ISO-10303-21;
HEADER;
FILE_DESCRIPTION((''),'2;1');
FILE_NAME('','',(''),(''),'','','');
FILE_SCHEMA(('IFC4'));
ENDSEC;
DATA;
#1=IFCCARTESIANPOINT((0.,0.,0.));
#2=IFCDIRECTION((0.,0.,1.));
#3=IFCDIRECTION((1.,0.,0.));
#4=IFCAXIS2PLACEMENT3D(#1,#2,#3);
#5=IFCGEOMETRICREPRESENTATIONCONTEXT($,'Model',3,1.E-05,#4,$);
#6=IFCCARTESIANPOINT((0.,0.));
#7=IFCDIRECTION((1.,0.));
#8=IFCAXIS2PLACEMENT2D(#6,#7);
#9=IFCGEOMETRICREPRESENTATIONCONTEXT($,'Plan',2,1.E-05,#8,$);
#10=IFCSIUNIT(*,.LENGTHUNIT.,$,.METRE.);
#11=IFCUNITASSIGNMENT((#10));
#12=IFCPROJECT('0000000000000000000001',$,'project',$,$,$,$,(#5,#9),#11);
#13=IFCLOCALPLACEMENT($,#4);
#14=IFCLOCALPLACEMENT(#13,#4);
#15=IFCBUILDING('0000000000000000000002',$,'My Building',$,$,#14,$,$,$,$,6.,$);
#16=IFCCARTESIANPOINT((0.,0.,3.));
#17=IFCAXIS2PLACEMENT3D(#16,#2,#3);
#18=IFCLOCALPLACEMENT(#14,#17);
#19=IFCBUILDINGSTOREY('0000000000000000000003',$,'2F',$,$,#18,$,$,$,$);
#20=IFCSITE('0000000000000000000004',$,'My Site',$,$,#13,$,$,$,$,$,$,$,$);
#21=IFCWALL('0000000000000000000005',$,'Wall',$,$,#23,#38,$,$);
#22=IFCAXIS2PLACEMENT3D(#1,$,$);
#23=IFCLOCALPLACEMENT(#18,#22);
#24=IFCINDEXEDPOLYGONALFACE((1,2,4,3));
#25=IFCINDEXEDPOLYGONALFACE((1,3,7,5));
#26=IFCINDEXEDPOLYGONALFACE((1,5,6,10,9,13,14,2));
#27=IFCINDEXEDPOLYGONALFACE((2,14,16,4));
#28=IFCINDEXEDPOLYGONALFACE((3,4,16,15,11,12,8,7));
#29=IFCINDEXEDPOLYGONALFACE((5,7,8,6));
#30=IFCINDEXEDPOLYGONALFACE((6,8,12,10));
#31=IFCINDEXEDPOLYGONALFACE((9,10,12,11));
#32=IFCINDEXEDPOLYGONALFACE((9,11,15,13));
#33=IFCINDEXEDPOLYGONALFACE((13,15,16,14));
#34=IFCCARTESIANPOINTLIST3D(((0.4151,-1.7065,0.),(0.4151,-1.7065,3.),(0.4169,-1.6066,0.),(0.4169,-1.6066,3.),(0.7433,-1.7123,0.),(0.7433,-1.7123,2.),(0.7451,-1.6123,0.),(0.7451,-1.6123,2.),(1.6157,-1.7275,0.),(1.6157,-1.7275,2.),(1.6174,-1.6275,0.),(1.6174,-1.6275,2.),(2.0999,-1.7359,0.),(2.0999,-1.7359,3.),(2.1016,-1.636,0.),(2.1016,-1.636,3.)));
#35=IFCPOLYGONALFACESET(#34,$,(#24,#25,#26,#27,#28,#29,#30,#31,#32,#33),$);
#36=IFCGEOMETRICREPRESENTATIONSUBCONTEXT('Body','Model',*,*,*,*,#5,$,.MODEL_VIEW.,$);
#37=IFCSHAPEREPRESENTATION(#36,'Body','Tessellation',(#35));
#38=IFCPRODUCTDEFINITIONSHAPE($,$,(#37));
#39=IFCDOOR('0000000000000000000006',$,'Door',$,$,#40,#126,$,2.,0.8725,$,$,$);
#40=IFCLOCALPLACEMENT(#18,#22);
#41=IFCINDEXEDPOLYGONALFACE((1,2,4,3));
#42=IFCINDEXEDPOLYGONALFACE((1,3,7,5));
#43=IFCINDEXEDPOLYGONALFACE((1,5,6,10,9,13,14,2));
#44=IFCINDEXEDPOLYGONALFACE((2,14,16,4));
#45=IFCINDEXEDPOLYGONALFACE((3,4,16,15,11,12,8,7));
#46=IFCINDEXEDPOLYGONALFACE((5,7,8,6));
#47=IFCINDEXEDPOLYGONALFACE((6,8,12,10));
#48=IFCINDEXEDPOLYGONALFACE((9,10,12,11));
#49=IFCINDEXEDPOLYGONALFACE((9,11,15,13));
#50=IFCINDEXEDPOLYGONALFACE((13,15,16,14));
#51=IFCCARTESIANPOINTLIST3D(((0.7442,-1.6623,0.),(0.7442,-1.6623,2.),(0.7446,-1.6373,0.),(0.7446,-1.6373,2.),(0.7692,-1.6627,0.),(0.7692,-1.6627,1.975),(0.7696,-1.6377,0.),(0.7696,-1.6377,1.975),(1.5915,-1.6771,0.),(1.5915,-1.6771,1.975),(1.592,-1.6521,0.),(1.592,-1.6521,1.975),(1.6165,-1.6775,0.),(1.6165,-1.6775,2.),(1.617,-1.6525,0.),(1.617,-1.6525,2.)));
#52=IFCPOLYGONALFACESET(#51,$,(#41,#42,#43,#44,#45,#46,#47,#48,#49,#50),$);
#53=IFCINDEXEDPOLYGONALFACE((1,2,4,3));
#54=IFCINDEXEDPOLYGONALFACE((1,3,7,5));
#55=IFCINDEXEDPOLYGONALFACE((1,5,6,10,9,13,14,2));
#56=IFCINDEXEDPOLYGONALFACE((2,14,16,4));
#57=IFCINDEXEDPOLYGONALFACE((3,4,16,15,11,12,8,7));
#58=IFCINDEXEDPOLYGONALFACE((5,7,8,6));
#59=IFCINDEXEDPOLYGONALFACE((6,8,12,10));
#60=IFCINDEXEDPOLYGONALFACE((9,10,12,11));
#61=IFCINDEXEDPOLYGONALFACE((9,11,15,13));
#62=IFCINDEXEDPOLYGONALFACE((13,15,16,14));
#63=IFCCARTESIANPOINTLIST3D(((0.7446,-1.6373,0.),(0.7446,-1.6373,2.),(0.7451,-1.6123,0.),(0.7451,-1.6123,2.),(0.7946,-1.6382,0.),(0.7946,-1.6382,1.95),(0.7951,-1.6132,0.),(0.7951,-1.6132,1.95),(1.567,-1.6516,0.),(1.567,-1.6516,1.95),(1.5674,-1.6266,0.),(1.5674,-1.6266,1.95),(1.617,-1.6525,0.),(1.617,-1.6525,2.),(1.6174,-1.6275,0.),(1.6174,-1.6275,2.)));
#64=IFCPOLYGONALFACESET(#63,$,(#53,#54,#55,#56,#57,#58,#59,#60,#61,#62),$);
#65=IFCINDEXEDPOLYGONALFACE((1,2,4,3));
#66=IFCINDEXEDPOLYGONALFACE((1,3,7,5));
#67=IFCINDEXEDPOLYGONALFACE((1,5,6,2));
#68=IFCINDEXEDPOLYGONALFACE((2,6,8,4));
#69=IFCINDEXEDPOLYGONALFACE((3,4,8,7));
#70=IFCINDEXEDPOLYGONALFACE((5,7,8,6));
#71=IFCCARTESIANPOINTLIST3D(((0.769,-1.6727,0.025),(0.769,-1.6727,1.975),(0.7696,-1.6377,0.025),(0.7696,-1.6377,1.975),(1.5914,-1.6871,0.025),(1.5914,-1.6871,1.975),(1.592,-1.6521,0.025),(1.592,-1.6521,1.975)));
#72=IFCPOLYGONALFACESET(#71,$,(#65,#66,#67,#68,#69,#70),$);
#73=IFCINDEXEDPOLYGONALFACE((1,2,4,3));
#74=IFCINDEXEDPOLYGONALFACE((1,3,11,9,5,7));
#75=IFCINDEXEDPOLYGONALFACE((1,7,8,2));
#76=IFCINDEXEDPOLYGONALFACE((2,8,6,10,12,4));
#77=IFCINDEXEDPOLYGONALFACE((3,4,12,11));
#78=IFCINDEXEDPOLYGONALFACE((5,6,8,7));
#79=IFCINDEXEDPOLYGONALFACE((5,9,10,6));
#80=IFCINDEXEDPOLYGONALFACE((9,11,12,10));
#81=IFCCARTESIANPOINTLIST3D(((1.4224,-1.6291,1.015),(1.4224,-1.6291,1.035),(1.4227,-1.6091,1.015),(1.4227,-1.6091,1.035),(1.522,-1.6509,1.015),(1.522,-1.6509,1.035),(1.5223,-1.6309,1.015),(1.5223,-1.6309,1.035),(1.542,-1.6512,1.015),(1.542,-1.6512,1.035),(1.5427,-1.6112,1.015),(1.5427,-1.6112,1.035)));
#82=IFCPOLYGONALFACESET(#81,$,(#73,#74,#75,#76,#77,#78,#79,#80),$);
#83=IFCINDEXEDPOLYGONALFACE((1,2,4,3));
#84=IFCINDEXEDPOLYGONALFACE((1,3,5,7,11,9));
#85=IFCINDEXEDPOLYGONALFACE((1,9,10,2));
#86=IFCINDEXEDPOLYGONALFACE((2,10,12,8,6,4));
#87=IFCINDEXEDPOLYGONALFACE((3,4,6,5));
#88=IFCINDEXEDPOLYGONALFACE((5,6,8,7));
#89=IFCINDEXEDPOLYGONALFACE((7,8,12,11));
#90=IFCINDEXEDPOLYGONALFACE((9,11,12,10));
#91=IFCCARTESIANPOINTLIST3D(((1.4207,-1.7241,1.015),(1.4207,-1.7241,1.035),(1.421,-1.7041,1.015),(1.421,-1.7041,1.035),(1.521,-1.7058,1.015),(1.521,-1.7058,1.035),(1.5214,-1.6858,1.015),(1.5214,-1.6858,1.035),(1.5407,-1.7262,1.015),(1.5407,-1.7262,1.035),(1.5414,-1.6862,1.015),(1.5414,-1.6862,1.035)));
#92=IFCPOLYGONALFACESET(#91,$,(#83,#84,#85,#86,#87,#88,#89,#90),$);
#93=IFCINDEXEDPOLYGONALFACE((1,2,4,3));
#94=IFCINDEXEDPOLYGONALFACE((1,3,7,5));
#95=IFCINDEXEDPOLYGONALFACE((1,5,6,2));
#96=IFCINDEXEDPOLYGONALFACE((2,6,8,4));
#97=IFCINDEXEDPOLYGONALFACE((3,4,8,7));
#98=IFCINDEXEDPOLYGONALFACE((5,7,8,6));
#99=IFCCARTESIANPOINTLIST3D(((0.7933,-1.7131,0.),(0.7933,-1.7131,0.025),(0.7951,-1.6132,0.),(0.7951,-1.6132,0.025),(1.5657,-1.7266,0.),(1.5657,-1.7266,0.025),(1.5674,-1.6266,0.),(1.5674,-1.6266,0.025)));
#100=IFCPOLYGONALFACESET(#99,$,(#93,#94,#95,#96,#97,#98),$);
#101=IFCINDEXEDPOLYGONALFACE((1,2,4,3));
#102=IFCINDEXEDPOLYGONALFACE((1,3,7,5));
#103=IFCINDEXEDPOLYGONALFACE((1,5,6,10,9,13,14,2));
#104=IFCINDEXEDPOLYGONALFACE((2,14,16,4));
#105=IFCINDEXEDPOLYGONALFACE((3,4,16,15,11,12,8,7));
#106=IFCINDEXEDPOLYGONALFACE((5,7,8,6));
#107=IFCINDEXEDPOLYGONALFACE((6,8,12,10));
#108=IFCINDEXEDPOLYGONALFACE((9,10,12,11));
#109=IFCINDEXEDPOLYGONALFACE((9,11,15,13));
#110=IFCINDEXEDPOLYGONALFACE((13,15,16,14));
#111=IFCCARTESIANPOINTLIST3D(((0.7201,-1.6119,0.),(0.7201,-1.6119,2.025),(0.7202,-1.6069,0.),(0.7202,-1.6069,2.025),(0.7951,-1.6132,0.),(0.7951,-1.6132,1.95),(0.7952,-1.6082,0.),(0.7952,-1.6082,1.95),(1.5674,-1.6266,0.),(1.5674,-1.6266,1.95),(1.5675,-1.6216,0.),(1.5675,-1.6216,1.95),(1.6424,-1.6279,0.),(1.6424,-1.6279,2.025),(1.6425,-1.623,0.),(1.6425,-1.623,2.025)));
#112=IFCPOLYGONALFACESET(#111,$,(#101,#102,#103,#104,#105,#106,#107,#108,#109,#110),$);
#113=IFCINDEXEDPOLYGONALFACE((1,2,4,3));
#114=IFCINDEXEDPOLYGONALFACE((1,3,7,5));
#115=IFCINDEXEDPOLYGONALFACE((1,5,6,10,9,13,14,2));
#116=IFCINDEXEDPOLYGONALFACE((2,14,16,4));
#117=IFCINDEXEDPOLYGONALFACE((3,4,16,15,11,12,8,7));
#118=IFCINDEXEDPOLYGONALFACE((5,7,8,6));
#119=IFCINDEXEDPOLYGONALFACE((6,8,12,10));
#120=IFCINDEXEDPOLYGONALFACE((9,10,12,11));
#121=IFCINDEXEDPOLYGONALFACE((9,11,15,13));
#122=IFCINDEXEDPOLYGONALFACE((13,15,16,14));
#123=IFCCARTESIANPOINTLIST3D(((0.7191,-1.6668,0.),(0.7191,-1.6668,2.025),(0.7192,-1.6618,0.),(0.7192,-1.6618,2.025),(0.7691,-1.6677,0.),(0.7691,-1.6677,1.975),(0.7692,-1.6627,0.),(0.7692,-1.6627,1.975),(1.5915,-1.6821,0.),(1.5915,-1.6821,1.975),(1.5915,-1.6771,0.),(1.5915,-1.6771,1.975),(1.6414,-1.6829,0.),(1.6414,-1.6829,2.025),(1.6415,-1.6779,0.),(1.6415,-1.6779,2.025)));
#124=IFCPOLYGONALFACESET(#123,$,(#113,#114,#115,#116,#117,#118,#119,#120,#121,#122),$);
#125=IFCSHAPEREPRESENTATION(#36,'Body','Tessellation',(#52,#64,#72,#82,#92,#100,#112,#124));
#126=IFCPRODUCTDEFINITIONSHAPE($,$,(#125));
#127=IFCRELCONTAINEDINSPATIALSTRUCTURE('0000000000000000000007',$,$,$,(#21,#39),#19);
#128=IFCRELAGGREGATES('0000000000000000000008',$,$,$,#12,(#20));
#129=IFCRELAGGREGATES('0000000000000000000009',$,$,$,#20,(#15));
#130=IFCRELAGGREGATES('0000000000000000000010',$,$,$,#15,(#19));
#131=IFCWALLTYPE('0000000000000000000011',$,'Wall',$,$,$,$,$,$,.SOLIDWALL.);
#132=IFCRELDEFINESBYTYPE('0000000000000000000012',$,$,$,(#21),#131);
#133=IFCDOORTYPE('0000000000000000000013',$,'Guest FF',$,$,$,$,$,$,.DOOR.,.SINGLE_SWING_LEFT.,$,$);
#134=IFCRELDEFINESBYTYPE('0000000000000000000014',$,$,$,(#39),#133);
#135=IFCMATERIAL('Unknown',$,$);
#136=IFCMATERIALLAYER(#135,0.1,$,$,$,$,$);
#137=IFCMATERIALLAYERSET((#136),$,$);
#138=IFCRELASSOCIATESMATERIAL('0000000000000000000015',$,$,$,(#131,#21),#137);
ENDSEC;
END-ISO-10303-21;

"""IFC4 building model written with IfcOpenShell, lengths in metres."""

from ifc_helpers import new_model, entity, si_unit, frame, origin_with_axes, origin_2d_with_axis, place, context, subcontext, project, spatial, line, indexed_curve, outline, extrude, shape, source, transform, mapped, material, layer, layer_set, layer_usage, type_object, type_shapes, element, fill, save


model = new_model("IFC4")

# Units and contexts
model_context = context("Model", 3, precision=1e-05, world=origin_with_axes())
plan_context = context("Plan", 2, precision=1e-05, world=origin_2d_with_axis())
body_context_1 = subcontext(model_context, "Body", "Model", "MODEL_VIEW")
body_context_2 = subcontext(plan_context, "Body", "Plan", "PLAN_VIEW")
ifc_project = project(units=[si_unit("LENGTHUNIT", "METRE")], contexts=[model_context, plan_context])

# Site, building, storey
site_placement = place(None, origin_with_axes())
site = spatial("IfcSite", under=ifc_project, at=site_placement, Name="My Site")
building_placement = place(site_placement, origin_with_axes())
building = spatial("IfcBuilding", under=site, at=building_placement, Name="My Building", ElevationOfTerrain=6.0)
storey_placement = place(building_placement, frame((0.0, 0.0, 3.0), z_axis=(0.0, 0.0, 1.0), x_axis=(1.0, 0.0, 0.0)))
storey = spatial("IfcBuildingStorey", under=building, at=storey_placement, Name="2F")

# Shared definitions
ifc_material_1 = material(Name="Unknown")

# Shared definitions
ifc_layer_1 = layer(ifc_material_1, 0.1)
ifc_layer_set_1 = layer_set([ifc_layer_1])
wall_type = type_object("IfcWallType", Name="Wall", PredefinedType="SOLIDWALL", material=ifc_layer_set_1)

# Wall, opening, door
ifc_layer_usage_1 = layer_usage(ifc_layer_set_1, "AXIS2", "POSITIVE", 0.0)
wall_1_placement = place(storey_placement, frame((2.1016, -1.636, 0.0), z_axis=(0.0, 0.0, 1.0), x_axis=(-0.999848, 0.017453, 0.0)))
wall_1 = element("IfcWall", 1, at=wall_1_placement, inside=storey, type_object=wall_type, material=ifc_layer_usage_1, Name="Wall", context=body_context_1, shape_type="SweptSolid", body=[
    extrude(outline(indexed_curve([(0.0, 0.0), (0.0, 0.1), (1.685, 0.1), (1.685, 0.0)], segments=[line(1, 2, 3, 4, 1)])), origin_with_axes(), (0.0, 0.0, 1.0), 3.0),
])
shared_shape_1 = source(origin_with_axes(), body_context_1, "Body", "SweptSolid", [
    extrude(outline(indexed_curve([(0.0, 0.0), (0.8725, 0.0), (0.8725, 2.0), (0.0, 2.0)], segments=[line(1, 2, 3, 4, 1)])), frame((0.0, -0.6, 0.0), z_axis=(0.0, -1.0, 0.0), x_axis=(1.0, 0.0, 0.0)), (0.0, 0.0, -1.0), 1.2),
])
opening_1_placement = place(wall_1_placement, frame((0.4843, 0.0, 0.0), z_axis=(0.0, 0.0, 1.0), x_axis=(1.0, 0.0, 0.0)))
opening_1 = element("IfcOpeningElement", 2, at=opening_1_placement, cuts=wall_1, PredefinedType="OPENING", context=body_context_1, shape_type="MappedRepresentation", body=[
    mapped(shared_shape_1, transform((0.0, 0.0, 0.0), x_axis=(1.0, 0.0, 0.0), y_axis=(0.0, 1.0, 0.0), z_axis=(0.0, 0.0, 1.0), scale=1.0)),
])
door_type_1 = type_object("IfcDoorType", Name="Guest FF", OperationType="SINGLE_SWING_LEFT", PredefinedType="DOOR")
shared_shape_2 = source(origin_with_axes(), body_context_1, "Body", "SweptSolid", [
    extrude(outline(indexed_curve([(0.0, 0.0), (0.0, 2.0), (0.8725, 2.0), (0.8725, 0.0), (0.8475, 0.0), (0.8475, 1.975), (0.025, 1.975), (0.025, 0.0)], segments=[line(1, 2, 3, 4, 5, 6, 7, 8, 1)])), frame((0.0, 0.025, 0.0), z_axis=(0.0, -1.0, 0.0), x_axis=(1.0, 0.0, 0.0)), (0.0, 0.0, -1.0), 0.025),
    extrude(outline(indexed_curve([(0.0, 0.0), (0.0, 2.0), (0.8725, 2.0), (0.8725, 0.0), (0.8225, 0.0), (0.8225, 1.95), (0.05, 1.95), (0.05, 0.0)], segments=[line(1, 2, 3, 4, 5, 6, 7, 8, 1)])), frame((0.0, 0.0, 0.0), z_axis=(0.0, -1.0, 0.0), x_axis=(1.0, 0.0, 0.0)), (0.0, 0.0, -1.0), 0.025),
    extrude(outline(indexed_curve([(0.0, 0.0), (0.8225, 0.0), (0.8225, 0.035), (0.0, 0.035)], segments=[line(1, 2, 3, 4, 1)])), frame((0.025, 0.025, 0.025), z_axis=(0.0, 0.0, 1.0), x_axis=(1.0, 0.0, 0.0)), (0.0, 0.0, 1.0), 1.95),
    extrude(outline(indexed_curve([(0.0, 0.0), (0.0, -0.04), (0.12, -0.04), (0.12, -0.02), (0.02, -0.02), (0.02, 0.0)], segments=[line(1, 2, 3, 4, 5, 6, 1)])), frame((0.075, 0.025, 1.015), z_axis=(0.0, 0.0, 1.0), x_axis=(1.0, 0.0, 0.0)), (0.0, 0.0, 1.0), 0.02),
    extrude(outline(indexed_curve([(0.0, 0.0), (0.0, 0.04), (0.12, 0.04), (0.12, 0.02), (0.02, 0.02), (0.02, 0.0)], segments=[line(1, 2, 3, 4, 5, 6, 1)])), frame((0.075, 0.06, 1.015), z_axis=(0.0, 0.0, 1.0), x_axis=(1.0, 0.0, 0.0)), (0.0, 0.0, 1.0), 0.02),
    extrude(outline(indexed_curve([(0.0, 0.0), (0.7725, 0.0), (0.7725, 0.1), (0.0, 0.1)], segments=[line(1, 2, 3, 4, 1)])), frame((0.05, 0.0, 0.0), z_axis=(0.0, 0.0, 1.0), x_axis=(1.0, 0.0, 0.0)), (0.0, 0.0, 1.0), 0.025),
    extrude(outline(indexed_curve([(0.0, 0.0), (0.0, 2.025), (0.9225, 2.025), (0.9225, 0.0), (0.8475, 0.0), (0.8475, 1.95), (0.075, 1.95), (0.075, 0.0)], segments=[line(1, 2, 3, 4, 5, 6, 7, 8, 1)])), frame((-0.025, -0.005, 0.0), z_axis=(0.0, -1.0, 0.0), x_axis=(1.0, 0.0, 0.0)), (0.0, 0.0, -1.0), 0.005),
    extrude(outline(indexed_curve([(0.0, 0.0), (0.0, 2.025), (0.9225, 2.025), (0.9225, 0.0), (0.8725, 0.0), (0.8725, 1.975), (0.05, 1.975), (0.05, 0.0)], segments=[line(1, 2, 3, 4, 5, 6, 7, 8, 1)])), frame((-0.025, 0.05, 0.0), z_axis=(0.0, -1.0, 0.0), x_axis=(1.0, 0.0, 0.0)), (0.0, 0.0, -1.0), 0.005),
])
shared_shape_3 = source(origin_with_axes(), body_context_2, "Body", "Curve2D", [
    entity("IfcIndexedPolyCurve", entity("IfcCartesianPointList2D", [[0.0, 0.0], [0.0, 0.05], [0.025, 0.05], [0.025, 0.025], [0.05, 0.025], [0.05, 0.0]]), [entity("IfcLineIndex", [1, 2, 3, 4, 5, 6, 1])]),
    entity("IfcIndexedPolyCurve", entity("IfcCartesianPointList2D", [[0.8725, 0.0], [0.8725, 0.05], [0.8475, 0.05], [0.8475, 0.025], [0.8225, 0.025], [0.8225, 0.0]]), [entity("IfcLineIndex", [1, 2, 3, 4, 5, 6, 1])]),
    entity("IfcTrimmedCurve", entity("IfcEllipse", entity("IfcAxis2Placement2D", entity("IfcCartesianPoint", [0.8125, 0.05]), entity("IfcDirection", [1.0, 0.0])), 0.7875, 0.8225), [entity("IfcCartesianPoint", [0.8125, 0.8725])], [entity("IfcCartesianPoint", [0.025, 0.05])], True, "CARTESIAN"),
    entity("IfcIndexedPolyCurve", entity("IfcCartesianPointList2D", [[0.8475, 0.05], [0.8125, 0.05], [0.8125, 0.8725], [0.8475, 0.8725]]), [entity("IfcLineIndex", [1, 2, 3, 4, 1])]),
])
type_shapes(door_type_1, [shared_shape_2, shared_shape_3])
door_1_placement = place(opening_1_placement, frame((0.0, 0.0, 0.0), z_axis=(0.0, 0.0, 1.0), x_axis=(1.0, 0.0, 0.0)))
door_1 = element("IfcDoor", 3, at=door_1_placement, inside=storey, type_object=door_type_1, Name="Door", OverallHeight=2.0, OverallWidth=0.8725, shapes=[
    shape(body_context_1, "Body", "MappedRepresentation", [mapped(shared_shape_2, transform((0.0, 0.0, 0.0), x_axis=(1.0, 0.0, 0.0), y_axis=(0.0, 1.0, 0.0), z_axis=(0.0, 0.0, 1.0), scale=1.0))]),
    shape(body_context_2, "Body", "MappedRepresentation", [mapped(shared_shape_3, transform((0.0, 0.0, 0.0), x_axis=(1.0, 0.0, 0.0), y_axis=(0.0, 1.0, 0.0), z_axis=(0.0, 0.0, 1.0), scale=1.0))]),
])
fill(opening_1, door_1)

save(model, "model.ifc")
